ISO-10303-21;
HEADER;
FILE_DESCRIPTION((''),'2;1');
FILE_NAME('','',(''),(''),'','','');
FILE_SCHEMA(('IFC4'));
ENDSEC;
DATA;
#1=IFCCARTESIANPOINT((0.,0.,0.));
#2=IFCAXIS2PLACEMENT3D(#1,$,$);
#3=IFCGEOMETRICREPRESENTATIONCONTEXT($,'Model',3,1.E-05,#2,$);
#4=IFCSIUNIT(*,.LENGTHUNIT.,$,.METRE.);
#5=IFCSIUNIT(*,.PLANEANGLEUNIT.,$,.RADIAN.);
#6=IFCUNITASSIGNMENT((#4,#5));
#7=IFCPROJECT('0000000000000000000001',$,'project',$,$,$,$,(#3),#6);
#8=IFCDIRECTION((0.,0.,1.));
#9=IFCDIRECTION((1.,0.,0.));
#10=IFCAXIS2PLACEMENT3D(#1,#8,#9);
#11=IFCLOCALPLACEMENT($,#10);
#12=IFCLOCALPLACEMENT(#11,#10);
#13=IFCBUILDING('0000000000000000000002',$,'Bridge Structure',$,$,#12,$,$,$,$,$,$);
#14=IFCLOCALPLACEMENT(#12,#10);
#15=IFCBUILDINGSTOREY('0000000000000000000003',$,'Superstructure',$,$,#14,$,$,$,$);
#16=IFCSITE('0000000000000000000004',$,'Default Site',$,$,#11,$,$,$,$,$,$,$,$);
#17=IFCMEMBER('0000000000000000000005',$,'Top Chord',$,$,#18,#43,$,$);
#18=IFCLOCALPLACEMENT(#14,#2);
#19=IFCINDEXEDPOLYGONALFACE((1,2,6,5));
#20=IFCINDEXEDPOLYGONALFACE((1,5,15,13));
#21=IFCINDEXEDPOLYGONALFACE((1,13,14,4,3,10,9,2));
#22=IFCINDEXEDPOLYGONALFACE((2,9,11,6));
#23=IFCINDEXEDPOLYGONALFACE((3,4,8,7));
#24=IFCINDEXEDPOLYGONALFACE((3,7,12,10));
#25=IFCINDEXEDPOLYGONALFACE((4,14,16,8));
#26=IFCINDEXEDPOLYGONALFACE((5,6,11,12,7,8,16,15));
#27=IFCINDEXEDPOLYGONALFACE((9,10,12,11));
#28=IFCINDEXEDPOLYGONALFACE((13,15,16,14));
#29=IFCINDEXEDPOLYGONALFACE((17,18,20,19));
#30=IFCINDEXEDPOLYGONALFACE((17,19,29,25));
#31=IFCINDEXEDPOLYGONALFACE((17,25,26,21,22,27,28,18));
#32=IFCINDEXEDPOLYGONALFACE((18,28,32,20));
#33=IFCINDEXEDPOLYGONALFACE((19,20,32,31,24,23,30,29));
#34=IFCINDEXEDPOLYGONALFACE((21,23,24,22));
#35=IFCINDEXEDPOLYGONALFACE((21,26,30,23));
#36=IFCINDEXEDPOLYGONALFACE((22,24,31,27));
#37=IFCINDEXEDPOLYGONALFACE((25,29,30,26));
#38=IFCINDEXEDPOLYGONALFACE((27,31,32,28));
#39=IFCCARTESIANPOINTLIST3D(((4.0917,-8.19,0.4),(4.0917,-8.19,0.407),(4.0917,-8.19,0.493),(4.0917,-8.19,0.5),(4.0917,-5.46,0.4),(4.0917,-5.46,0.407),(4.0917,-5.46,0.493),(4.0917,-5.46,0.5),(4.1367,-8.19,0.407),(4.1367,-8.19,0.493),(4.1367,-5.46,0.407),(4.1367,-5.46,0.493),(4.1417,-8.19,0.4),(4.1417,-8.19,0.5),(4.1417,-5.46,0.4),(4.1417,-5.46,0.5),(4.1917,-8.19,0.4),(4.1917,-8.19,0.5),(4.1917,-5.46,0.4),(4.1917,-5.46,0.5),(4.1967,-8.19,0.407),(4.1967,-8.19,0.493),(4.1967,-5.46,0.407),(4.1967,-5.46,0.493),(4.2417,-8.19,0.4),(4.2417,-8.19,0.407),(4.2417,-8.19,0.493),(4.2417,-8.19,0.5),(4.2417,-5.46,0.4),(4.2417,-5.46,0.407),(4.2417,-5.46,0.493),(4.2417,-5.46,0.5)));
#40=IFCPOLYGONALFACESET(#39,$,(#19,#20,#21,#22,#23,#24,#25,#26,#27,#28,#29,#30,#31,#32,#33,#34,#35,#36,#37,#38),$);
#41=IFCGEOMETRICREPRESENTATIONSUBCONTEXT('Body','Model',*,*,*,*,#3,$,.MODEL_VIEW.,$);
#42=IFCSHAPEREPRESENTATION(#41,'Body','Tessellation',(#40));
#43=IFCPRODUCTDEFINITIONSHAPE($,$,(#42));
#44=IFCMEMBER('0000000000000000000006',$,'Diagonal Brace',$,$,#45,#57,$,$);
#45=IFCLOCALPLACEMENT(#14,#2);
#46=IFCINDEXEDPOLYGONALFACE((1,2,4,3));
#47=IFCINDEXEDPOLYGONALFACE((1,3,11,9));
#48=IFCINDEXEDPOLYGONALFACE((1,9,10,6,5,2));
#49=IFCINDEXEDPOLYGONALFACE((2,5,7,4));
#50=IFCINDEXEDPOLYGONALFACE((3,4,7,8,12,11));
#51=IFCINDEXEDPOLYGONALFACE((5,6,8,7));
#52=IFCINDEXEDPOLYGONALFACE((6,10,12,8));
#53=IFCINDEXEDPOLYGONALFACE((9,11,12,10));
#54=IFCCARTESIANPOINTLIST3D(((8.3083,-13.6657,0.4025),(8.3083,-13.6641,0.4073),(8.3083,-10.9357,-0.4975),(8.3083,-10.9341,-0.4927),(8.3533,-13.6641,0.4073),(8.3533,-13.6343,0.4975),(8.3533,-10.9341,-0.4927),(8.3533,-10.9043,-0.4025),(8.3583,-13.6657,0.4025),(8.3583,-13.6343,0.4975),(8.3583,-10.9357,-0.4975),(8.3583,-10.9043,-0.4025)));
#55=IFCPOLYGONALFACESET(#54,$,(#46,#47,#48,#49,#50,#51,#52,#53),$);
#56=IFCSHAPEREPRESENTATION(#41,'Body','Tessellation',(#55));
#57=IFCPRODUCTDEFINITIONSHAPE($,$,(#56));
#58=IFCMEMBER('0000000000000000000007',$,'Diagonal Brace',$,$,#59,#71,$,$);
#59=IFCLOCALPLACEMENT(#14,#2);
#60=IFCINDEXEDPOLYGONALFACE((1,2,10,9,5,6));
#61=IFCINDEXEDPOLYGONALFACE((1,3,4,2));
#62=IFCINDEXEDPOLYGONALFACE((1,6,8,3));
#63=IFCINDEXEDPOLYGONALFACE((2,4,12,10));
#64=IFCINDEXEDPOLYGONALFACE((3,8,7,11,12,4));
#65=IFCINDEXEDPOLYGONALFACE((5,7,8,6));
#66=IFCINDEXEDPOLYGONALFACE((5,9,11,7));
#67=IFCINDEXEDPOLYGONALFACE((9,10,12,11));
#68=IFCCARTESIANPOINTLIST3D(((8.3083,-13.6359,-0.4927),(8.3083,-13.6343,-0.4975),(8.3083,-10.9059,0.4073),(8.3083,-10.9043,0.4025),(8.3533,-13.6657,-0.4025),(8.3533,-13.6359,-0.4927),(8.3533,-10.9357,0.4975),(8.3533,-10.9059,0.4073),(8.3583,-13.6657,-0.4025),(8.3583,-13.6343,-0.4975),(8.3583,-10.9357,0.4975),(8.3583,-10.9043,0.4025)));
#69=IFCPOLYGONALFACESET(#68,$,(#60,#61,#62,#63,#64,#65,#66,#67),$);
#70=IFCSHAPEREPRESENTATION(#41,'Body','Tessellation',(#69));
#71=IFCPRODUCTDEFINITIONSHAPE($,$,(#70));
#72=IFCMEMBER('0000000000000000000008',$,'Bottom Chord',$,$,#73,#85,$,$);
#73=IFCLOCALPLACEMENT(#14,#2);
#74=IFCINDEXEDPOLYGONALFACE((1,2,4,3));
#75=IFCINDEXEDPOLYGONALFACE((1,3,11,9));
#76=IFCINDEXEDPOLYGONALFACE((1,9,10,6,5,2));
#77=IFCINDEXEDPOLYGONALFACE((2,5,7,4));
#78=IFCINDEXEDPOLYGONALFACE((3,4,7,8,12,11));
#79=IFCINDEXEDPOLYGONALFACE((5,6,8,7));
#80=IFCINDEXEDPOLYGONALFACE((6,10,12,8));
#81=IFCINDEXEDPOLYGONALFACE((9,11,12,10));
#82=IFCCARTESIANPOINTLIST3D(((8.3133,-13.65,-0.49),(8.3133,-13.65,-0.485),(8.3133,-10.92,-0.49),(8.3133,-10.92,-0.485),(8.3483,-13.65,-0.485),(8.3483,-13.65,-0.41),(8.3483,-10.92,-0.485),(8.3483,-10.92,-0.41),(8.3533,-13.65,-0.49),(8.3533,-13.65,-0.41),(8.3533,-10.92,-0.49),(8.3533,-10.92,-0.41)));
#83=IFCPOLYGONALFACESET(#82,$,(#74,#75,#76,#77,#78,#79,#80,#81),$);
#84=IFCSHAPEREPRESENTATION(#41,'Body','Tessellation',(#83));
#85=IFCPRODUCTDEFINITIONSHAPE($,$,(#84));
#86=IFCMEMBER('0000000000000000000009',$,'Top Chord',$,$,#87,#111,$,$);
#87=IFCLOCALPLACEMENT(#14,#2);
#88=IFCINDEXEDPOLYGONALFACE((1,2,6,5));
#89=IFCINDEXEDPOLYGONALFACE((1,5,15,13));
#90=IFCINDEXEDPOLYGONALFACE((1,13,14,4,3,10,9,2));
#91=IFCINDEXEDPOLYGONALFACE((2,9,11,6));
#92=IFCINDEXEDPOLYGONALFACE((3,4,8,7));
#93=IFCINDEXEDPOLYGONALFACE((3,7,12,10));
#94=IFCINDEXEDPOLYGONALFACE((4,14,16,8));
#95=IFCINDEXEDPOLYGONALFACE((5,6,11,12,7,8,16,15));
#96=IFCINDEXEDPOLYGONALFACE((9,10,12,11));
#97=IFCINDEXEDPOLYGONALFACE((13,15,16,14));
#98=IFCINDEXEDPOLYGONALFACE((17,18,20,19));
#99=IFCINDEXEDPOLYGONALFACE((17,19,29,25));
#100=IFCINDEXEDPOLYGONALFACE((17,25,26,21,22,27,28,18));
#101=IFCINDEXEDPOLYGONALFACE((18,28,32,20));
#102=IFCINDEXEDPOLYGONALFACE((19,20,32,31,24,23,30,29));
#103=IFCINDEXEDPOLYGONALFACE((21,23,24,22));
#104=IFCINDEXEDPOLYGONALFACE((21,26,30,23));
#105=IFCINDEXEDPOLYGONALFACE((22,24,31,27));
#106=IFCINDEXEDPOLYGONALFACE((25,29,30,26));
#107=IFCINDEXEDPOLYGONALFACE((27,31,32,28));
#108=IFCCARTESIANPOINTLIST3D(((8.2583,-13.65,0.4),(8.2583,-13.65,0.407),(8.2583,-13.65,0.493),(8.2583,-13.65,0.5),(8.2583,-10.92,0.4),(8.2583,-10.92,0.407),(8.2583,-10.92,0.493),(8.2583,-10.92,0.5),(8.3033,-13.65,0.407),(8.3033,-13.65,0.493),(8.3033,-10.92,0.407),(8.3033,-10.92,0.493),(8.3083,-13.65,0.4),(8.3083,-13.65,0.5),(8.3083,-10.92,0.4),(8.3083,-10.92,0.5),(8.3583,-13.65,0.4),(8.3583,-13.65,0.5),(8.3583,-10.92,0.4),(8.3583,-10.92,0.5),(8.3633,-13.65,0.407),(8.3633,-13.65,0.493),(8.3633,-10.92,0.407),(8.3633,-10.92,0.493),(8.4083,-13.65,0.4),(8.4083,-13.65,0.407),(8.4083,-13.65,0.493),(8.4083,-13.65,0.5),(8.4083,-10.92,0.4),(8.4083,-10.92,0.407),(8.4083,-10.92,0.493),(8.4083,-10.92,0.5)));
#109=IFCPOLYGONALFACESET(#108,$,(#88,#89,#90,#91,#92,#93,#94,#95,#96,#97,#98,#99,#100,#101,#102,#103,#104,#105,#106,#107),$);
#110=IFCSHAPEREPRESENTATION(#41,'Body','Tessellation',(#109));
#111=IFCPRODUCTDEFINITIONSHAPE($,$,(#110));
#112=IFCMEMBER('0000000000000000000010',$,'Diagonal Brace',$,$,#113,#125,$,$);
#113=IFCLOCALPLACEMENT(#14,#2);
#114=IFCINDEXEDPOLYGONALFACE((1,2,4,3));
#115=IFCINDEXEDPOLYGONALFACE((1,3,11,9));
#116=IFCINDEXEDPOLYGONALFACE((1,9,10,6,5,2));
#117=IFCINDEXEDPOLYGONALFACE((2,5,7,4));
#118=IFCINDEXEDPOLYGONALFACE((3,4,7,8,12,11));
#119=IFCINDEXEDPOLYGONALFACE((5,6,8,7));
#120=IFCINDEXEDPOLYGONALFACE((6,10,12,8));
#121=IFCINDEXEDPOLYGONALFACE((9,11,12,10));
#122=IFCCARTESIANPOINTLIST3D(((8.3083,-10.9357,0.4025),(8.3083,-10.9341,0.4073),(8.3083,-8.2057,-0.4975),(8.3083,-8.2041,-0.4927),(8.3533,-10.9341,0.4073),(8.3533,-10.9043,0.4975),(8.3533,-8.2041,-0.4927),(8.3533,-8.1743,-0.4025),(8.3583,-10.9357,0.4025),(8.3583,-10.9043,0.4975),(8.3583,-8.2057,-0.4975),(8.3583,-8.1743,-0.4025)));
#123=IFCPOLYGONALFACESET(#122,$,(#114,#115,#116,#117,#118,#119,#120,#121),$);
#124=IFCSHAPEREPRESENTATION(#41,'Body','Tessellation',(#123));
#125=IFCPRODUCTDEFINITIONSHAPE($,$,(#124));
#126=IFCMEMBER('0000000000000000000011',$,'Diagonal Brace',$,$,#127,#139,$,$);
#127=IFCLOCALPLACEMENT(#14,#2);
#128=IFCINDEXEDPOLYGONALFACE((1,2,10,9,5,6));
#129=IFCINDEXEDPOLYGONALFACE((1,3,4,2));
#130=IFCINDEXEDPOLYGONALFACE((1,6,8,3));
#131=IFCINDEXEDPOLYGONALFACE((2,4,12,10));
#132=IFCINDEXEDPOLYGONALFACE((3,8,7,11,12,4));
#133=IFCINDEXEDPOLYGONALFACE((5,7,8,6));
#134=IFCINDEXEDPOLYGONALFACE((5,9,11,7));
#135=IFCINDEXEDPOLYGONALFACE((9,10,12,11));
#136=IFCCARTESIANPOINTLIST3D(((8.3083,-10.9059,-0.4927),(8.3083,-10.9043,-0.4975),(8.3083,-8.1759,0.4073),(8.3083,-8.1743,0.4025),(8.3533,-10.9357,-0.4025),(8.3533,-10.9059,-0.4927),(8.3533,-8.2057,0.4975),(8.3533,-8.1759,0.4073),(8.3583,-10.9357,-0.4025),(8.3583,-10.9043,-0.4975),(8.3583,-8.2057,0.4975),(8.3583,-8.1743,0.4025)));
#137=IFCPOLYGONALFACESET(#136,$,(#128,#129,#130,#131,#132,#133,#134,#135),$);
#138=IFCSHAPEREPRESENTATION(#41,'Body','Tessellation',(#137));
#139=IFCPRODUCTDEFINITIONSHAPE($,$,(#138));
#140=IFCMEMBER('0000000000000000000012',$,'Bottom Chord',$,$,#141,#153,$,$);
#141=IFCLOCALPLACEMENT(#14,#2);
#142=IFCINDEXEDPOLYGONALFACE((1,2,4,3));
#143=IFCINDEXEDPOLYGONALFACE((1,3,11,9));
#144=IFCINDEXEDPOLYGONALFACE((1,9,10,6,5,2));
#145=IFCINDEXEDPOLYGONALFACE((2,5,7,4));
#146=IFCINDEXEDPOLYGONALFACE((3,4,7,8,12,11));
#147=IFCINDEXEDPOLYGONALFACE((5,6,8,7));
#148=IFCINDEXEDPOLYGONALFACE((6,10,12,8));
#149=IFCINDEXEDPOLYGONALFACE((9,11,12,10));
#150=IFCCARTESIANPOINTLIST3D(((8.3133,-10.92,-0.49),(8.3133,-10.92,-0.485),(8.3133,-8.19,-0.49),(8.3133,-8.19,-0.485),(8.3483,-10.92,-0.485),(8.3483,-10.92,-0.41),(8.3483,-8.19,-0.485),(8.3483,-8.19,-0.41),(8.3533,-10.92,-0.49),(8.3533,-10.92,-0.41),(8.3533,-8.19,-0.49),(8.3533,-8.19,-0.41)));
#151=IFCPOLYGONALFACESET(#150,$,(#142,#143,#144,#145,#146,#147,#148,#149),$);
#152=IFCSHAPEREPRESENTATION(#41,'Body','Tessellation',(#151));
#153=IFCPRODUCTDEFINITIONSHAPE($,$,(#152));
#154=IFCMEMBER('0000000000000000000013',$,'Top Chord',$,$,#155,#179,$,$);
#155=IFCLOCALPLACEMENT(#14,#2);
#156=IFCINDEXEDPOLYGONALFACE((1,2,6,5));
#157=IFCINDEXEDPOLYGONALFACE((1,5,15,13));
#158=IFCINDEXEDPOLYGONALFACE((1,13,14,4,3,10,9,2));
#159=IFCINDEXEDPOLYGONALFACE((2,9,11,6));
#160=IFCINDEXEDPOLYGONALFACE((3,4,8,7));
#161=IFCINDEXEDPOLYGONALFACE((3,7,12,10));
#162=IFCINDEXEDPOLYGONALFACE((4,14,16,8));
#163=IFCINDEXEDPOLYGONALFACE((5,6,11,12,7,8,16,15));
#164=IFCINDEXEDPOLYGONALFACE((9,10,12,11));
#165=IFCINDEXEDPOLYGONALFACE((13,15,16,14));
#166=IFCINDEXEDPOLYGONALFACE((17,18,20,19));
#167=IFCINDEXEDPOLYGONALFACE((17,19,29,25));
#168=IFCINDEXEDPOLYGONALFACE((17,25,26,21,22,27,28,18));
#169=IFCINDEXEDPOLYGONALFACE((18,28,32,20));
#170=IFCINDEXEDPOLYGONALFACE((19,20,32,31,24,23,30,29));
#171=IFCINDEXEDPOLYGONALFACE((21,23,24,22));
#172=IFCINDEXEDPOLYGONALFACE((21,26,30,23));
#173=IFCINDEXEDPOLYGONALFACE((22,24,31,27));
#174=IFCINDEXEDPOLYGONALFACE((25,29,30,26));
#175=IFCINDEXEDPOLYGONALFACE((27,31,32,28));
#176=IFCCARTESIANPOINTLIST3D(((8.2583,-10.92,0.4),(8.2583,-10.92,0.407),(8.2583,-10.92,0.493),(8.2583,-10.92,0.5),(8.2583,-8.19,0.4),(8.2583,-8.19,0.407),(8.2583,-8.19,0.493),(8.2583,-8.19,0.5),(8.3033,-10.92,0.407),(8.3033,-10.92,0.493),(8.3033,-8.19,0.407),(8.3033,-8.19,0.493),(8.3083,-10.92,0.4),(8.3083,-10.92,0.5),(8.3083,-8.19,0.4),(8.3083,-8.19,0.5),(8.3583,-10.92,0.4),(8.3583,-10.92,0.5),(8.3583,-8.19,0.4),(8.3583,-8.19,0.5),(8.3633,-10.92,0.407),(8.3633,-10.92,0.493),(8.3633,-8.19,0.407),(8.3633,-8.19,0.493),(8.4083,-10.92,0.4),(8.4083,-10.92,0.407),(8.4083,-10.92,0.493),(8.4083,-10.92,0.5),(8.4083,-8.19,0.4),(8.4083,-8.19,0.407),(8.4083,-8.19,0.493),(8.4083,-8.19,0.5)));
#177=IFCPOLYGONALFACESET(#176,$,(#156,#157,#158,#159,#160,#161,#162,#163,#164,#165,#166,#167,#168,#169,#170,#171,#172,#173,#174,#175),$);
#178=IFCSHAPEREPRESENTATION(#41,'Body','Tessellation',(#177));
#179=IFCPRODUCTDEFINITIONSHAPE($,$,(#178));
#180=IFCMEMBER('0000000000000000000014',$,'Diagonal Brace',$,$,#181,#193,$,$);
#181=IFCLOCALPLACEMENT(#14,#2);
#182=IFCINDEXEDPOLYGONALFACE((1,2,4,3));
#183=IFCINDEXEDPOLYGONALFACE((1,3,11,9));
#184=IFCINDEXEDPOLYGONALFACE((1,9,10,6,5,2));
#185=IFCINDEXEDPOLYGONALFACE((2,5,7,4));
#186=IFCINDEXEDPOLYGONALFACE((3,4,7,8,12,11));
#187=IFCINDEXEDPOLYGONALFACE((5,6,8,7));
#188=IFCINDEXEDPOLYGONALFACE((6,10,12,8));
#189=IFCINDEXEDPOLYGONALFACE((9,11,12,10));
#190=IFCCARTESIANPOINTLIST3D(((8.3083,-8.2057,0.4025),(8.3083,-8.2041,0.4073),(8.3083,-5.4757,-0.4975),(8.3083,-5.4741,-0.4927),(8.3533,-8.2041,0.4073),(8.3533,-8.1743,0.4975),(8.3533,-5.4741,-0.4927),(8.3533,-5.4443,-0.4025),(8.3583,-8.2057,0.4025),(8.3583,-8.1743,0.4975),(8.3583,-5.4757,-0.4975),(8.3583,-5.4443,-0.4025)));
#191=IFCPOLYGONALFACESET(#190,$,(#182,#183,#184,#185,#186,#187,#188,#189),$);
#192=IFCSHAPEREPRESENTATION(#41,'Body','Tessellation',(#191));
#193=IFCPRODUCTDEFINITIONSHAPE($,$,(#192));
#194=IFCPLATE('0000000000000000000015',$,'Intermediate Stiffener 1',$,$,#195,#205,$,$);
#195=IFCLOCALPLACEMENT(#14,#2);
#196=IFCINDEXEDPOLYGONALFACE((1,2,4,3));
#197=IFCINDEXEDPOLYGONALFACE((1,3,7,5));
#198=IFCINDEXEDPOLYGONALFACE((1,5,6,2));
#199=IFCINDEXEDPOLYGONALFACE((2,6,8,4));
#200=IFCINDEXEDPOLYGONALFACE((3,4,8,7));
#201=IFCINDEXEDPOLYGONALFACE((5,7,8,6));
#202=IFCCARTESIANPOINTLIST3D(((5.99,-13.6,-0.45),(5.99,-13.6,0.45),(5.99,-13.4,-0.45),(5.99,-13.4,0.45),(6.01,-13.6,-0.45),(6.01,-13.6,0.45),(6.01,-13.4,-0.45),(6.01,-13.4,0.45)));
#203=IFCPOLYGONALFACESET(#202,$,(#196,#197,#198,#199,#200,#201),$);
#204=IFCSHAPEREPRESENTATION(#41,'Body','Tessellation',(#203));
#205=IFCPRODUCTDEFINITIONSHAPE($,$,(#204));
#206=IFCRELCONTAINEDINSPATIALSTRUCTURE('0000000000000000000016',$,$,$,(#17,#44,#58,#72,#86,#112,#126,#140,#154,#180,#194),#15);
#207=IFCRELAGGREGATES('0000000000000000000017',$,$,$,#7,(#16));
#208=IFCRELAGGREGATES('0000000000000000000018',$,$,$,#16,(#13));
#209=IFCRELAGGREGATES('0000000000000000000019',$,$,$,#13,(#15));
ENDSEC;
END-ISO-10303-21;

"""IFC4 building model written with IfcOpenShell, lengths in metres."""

from ifc_helpers import new_model, si_unit, frame, origin, origin_with_axes, origin_2d_with_axis, place, context, subcontext, project, spatial, polyline, rectangle, l_section, outline, composite_profile, extrude, element, save


model = new_model("IFC4")

# Units and contexts
model_context = context("Model", 3, precision=1e-05, world=origin())
body_context = subcontext(model_context, "Body", "Model", "MODEL_VIEW")
ifc_project = project(units=[si_unit("LENGTHUNIT", "METRE"), si_unit("PLANEANGLEUNIT", "RADIAN")], contexts=[model_context])

# Site, building, storey
site_placement = place(None, origin_with_axes())
site = spatial("IfcSite", under=ifc_project, at=site_placement, Name="Default Site")
building_placement = place(site_placement, origin_with_axes())
building = spatial("IfcBuilding", under=site, at=building_placement, Name="Bridge Structure")
storey_placement = place(building_placement, origin_with_axes())
storey = spatial("IfcBuildingStorey", under=building, at=storey_placement, Name="Superstructure")

# Members
member_1_placement = place(storey_placement, frame((4.1667, -8.19, 0.45), z_axis=(0.0, 1.0, 0.0), x_axis=(-1.0, 0.0, 0.0)))
element("IfcMember", 1, at=member_1_placement, inside=storey, Name="Top Chord", context=body_context, shape_type="SweptSolid", body=[
    extrude(composite_profile([outline(polyline([(-0.025, -0.05), (-0.025, 0.05), (-0.075, 0.05), (-0.075, 0.043), (-0.03, 0.043), (-0.03, -0.043), (-0.075, -0.043), (-0.075, -0.05), (-0.025, -0.05)])), outline(polyline([(0.025, -0.05), (0.075, -0.05), (0.075, -0.043), (0.03, -0.043), (0.03, 0.043), (0.075, 0.043), (0.075, 0.05), (0.025, 0.05), (0.025, -0.05)]))]), origin_with_axes(), (0.0, 0.0, 1.0), 2.73),
])
for number, where, z_axis, x_axis, name in (
    (2, (8.3333, -13.65, 0.45), (0.0, 0.949722, -0.313095), (-1.0, 0.0, 0.0), "Diagonal Brace"),
    (3, (8.3333, -13.65, -0.45), (0.0, 0.949722, 0.313095), (-1.0, 0.0, 0.0), "Diagonal Brace"),
):
    element("IfcMember", number, at=place(storey_placement, frame(where, z_axis=z_axis, x_axis=x_axis)), inside=storey, Name=name, context=body_context, shape_type="SweptSolid", body=[
        extrude(l_section(Depth=0.1, Width=0.05, Thickness=0.005, at=origin_2d_with_axis()), origin_with_axes(), (0.0, 0.0, 1.0), 2.8745),
    ])
member_2_placement = place(storey_placement, frame((8.3333, -13.65, -0.45), z_axis=(0.0, 1.0, 0.0), x_axis=(-1.0, 0.0, 0.0)))
element("IfcMember", 4, at=member_2_placement, inside=storey, Name="Bottom Chord", context=body_context, shape_type="SweptSolid", body=[
    extrude(l_section(Depth=0.08, Width=0.04, Thickness=0.005, at=origin_2d_with_axis()), origin_with_axes(), (0.0, 0.0, 1.0), 2.73),
])
member_3_placement = place(storey_placement, frame((8.3333, -13.65, 0.45), z_axis=(0.0, 1.0, 0.0), x_axis=(-1.0, 0.0, 0.0)))
element("IfcMember", 5, at=member_3_placement, inside=storey, Name="Top Chord", context=body_context, shape_type="SweptSolid", body=[
    extrude(composite_profile([outline(polyline([(-0.025, -0.05), (-0.025, 0.05), (-0.075, 0.05), (-0.075, 0.043), (-0.03, 0.043), (-0.03, -0.043), (-0.075, -0.043), (-0.075, -0.05), (-0.025, -0.05)])), outline(polyline([(0.025, -0.05), (0.075, -0.05), (0.075, -0.043), (0.03, -0.043), (0.03, 0.043), (0.075, 0.043), (0.075, 0.05), (0.025, 0.05), (0.025, -0.05)]))]), origin_with_axes(), (0.0, 0.0, 1.0), 2.73),
])
for number, where, z_axis, x_axis, name in (
    (6, (8.3333, -10.92, 0.45), (0.0, 0.949722, -0.313095), (-1.0, 0.0, 0.0), "Diagonal Brace"),
    (7, (8.3333, -10.92, -0.45), (0.0, 0.949722, 0.313095), (-1.0, 0.0, 0.0), "Diagonal Brace"),
):
    element("IfcMember", number, at=place(storey_placement, frame(where, z_axis=z_axis, x_axis=x_axis)), inside=storey, Name=name, context=body_context, shape_type="SweptSolid", body=[
        extrude(l_section(Depth=0.1, Width=0.05, Thickness=0.005, at=origin_2d_with_axis()), origin_with_axes(), (0.0, 0.0, 1.0), 2.8745),
    ])
member_4_placement = place(storey_placement, frame((8.3333, -10.92, -0.45), z_axis=(0.0, 1.0, 0.0), x_axis=(-1.0, 0.0, 0.0)))
element("IfcMember", 8, at=member_4_placement, inside=storey, Name="Bottom Chord", context=body_context, shape_type="SweptSolid", body=[
    extrude(l_section(Depth=0.08, Width=0.04, Thickness=0.005, at=origin_2d_with_axis()), origin_with_axes(), (0.0, 0.0, 1.0), 2.73),
])
member_5_placement = place(storey_placement, frame((8.3333, -10.92, 0.45), z_axis=(0.0, 1.0, 0.0), x_axis=(-1.0, 0.0, 0.0)))
element("IfcMember", 9, at=member_5_placement, inside=storey, Name="Top Chord", context=body_context, shape_type="SweptSolid", body=[
    extrude(composite_profile([outline(polyline([(-0.025, -0.05), (-0.025, 0.05), (-0.075, 0.05), (-0.075, 0.043), (-0.03, 0.043), (-0.03, -0.043), (-0.075, -0.043), (-0.075, -0.05), (-0.025, -0.05)])), outline(polyline([(0.025, -0.05), (0.075, -0.05), (0.075, -0.043), (0.03, -0.043), (0.03, 0.043), (0.075, 0.043), (0.075, 0.05), (0.025, 0.05), (0.025, -0.05)]))]), origin_with_axes(), (0.0, 0.0, 1.0), 2.73),
])
member_6_placement = place(storey_placement, frame((8.3333, -8.19, 0.45), z_axis=(0.0, 0.949722, -0.313095), x_axis=(-1.0, 0.0, 0.0)))
element("IfcMember", 10, at=member_6_placement, inside=storey, Name="Diagonal Brace", context=body_context, shape_type="SweptSolid", body=[
    extrude(l_section(Depth=0.1, Width=0.05, Thickness=0.005, at=origin_2d_with_axis()), origin_with_axes(), (0.0, 0.0, 1.0), 2.8745),
])

# Plate
for number, where, z_axis, x_axis, name in (
    (11, (6.0, -13.5, -0.45), (0.0, 0.0, 1.0), (1.0, 0.0, 0.0), "Intermediate Stiffener 1"),
):
    element("IfcPlate", number, at=place(storey_placement, frame(where, z_axis=z_axis, x_axis=x_axis)), inside=storey, Name=name, context=body_context, shape_type="SweptSolid", body=[
        extrude(rectangle(XDim=0.02, YDim=0.2, at=origin_2d_with_axis()), origin_with_axes(), (0.0, 0.0, 1.0), 0.9),
    ])

save(model, "model.ifc")
